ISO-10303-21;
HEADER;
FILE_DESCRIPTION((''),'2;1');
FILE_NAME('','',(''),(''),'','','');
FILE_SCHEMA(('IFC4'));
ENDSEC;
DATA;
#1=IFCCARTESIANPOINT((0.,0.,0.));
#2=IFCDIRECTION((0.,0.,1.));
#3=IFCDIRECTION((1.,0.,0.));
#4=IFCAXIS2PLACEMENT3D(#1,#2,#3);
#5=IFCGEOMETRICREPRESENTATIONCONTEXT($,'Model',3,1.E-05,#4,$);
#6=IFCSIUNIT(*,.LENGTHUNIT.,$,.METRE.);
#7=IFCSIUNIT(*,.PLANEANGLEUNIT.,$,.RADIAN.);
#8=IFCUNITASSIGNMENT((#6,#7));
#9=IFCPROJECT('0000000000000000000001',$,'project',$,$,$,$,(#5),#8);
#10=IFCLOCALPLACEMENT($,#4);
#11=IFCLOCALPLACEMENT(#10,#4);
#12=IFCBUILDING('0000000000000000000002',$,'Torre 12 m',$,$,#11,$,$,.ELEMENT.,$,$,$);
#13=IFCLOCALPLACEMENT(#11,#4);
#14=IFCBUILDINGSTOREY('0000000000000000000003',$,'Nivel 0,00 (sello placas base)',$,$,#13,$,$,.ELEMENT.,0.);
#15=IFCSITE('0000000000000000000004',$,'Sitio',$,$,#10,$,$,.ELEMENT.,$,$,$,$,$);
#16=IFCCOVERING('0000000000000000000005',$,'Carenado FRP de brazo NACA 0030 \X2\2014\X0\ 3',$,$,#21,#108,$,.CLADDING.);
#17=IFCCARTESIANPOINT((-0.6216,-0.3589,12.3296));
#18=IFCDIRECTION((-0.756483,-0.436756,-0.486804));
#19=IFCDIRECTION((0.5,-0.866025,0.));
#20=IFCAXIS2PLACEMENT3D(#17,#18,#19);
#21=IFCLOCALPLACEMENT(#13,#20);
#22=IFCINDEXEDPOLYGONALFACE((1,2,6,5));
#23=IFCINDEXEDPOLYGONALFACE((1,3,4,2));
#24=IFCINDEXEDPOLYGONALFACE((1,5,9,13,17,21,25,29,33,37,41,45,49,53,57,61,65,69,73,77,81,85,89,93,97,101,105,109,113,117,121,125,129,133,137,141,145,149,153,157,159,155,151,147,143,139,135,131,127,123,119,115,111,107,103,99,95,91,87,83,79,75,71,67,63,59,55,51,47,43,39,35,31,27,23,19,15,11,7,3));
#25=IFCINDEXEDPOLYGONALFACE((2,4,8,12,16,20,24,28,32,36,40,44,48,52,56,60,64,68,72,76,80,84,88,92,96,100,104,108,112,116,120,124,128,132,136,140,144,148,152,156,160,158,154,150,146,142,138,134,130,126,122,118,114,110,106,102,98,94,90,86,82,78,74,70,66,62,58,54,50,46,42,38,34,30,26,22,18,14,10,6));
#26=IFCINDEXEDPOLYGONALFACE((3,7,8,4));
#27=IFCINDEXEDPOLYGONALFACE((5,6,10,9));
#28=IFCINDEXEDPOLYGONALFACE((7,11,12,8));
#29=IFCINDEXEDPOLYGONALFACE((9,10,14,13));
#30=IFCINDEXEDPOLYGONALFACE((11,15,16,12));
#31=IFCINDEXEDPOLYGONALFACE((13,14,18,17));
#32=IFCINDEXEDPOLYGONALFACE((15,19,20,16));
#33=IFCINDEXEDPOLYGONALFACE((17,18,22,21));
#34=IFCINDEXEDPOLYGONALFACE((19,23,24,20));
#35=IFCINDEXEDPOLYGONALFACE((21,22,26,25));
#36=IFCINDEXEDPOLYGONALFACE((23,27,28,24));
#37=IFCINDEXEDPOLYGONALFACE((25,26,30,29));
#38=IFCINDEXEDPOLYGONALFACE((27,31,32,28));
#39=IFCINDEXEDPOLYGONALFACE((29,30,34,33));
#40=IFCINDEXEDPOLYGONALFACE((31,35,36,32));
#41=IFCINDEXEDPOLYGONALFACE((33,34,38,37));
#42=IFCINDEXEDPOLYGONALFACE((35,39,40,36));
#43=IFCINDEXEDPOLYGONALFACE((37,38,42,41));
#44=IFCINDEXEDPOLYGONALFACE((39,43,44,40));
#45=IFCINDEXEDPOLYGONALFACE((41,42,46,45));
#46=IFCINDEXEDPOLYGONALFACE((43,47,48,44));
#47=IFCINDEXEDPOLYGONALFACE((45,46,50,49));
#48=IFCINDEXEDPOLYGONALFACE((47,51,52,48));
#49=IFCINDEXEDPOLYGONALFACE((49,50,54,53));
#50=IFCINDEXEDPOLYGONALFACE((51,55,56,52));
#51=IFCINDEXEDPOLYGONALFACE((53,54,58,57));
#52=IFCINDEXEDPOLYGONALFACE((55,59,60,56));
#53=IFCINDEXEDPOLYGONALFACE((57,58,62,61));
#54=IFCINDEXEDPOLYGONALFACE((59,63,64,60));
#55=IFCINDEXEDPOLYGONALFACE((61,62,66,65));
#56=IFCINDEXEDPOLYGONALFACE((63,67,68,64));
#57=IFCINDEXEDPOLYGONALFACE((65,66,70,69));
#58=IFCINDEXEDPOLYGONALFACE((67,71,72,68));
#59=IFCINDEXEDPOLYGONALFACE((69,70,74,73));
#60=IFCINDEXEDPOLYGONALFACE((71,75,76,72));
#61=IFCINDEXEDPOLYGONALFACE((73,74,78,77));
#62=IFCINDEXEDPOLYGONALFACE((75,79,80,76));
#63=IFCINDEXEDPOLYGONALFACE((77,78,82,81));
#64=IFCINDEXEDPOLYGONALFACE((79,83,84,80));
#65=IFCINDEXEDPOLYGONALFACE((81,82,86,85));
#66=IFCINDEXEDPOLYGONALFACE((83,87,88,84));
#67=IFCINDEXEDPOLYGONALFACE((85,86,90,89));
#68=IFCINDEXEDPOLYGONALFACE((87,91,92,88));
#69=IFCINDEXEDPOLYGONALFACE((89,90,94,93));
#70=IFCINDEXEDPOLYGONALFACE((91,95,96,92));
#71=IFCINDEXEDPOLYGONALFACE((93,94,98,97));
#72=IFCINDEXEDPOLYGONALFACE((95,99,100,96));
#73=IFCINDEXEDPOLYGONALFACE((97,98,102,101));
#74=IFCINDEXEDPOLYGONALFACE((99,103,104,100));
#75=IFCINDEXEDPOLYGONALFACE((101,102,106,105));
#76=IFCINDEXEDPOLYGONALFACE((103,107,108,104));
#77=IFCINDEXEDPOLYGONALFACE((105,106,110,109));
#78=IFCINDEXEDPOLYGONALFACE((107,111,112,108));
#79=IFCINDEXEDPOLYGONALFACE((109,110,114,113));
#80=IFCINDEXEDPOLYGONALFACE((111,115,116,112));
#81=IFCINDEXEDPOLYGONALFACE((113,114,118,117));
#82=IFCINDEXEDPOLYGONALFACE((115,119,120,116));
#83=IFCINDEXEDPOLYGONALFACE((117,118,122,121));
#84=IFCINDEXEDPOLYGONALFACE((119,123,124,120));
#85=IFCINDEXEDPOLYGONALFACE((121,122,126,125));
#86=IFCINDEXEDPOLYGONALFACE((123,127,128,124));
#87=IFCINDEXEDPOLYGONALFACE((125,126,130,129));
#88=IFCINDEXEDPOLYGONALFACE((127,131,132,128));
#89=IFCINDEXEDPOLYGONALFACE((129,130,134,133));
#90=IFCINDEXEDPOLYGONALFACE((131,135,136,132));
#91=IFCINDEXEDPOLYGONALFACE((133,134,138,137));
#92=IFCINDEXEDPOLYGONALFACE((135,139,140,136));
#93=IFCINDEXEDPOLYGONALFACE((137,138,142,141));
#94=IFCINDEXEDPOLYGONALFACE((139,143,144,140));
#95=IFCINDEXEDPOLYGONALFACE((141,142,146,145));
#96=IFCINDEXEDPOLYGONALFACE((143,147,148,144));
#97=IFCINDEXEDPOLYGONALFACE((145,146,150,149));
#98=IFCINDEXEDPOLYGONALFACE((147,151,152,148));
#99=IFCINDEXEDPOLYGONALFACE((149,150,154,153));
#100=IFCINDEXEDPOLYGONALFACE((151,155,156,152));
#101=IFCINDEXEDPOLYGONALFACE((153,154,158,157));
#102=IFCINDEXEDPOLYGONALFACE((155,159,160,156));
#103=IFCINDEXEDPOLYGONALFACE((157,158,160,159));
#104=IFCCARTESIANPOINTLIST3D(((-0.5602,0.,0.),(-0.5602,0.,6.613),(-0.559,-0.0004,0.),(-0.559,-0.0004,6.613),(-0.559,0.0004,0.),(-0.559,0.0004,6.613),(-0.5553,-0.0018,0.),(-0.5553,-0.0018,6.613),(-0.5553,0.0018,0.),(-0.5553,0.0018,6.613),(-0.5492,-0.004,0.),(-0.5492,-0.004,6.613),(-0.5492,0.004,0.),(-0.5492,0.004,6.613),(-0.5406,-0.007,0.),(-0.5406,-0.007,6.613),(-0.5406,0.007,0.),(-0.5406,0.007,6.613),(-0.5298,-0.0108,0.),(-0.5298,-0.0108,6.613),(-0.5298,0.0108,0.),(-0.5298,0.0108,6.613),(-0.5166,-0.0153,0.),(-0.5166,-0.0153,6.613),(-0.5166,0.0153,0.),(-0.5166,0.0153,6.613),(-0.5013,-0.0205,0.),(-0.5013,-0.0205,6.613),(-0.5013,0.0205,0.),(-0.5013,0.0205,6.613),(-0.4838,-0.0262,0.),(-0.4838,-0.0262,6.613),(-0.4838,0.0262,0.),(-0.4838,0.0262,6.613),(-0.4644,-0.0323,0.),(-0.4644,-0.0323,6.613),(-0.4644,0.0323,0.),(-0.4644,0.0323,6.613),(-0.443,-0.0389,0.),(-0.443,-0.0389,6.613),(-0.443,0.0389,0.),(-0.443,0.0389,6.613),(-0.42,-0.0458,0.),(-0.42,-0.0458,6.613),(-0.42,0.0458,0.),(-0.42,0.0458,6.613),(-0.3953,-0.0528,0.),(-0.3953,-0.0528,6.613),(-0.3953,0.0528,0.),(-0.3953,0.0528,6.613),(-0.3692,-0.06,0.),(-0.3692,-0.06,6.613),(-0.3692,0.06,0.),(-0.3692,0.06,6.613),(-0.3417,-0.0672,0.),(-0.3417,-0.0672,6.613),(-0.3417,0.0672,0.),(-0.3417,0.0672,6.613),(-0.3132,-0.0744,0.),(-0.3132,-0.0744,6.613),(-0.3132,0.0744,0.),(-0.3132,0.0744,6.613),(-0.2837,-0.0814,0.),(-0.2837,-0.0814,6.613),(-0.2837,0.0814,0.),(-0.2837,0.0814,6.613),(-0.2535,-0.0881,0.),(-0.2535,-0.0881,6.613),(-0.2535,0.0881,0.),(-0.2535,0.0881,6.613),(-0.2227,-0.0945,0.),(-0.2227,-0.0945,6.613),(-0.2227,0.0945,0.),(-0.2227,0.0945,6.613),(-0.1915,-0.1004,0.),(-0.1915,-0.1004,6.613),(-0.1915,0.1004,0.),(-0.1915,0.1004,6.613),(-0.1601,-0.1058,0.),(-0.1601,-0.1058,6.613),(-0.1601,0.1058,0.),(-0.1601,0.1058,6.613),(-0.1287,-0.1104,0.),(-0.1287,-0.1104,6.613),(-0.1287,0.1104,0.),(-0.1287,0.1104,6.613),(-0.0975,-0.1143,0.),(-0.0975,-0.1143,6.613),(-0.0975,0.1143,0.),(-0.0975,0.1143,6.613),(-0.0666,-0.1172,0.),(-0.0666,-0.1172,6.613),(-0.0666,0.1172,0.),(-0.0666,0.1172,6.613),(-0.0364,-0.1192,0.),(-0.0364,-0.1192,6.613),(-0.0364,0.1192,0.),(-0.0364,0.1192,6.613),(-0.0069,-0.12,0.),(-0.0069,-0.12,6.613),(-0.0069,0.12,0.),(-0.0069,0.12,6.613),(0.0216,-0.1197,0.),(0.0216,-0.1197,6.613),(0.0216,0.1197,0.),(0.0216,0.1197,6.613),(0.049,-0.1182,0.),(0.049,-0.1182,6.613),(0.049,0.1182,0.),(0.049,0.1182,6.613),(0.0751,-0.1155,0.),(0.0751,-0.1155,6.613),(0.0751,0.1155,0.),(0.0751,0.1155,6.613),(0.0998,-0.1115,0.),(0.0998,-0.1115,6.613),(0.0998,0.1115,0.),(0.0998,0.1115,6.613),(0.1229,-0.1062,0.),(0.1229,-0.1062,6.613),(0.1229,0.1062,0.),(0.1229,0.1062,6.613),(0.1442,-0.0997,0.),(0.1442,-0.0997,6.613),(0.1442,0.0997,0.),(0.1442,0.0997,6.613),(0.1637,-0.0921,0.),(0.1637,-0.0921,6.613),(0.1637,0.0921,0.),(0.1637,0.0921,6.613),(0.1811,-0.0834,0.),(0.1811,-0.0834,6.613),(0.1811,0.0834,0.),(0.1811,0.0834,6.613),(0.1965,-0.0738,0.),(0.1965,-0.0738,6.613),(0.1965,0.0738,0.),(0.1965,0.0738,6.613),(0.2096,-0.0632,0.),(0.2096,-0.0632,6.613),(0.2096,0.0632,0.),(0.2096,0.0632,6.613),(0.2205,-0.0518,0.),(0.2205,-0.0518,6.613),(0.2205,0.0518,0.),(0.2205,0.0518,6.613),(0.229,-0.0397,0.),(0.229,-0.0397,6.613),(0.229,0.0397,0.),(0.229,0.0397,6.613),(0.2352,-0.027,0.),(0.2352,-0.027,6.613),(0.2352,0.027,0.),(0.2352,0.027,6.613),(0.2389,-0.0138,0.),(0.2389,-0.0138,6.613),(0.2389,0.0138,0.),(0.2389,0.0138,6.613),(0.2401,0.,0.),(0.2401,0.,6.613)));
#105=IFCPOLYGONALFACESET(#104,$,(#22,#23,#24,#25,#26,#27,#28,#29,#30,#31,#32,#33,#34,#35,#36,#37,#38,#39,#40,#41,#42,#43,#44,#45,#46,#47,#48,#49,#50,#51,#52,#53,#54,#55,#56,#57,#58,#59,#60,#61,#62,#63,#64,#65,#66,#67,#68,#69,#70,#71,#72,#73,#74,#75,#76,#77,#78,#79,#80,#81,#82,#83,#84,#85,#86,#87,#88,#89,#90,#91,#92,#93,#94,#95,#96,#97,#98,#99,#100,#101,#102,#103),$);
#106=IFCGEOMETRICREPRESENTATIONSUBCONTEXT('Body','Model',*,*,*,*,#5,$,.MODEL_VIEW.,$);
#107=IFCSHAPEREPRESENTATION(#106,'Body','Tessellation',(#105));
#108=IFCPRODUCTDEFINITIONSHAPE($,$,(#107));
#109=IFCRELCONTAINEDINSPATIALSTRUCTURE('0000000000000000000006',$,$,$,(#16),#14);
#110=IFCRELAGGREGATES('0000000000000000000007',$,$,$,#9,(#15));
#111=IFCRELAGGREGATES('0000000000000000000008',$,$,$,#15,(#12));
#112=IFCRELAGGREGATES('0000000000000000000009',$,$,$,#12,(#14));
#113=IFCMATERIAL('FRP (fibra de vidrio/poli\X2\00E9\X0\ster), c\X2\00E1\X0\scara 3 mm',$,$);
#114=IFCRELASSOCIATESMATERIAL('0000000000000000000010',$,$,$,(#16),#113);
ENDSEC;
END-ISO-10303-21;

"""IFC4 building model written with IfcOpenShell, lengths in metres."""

from ifc_helpers import new_model, si_unit, frame, origin, origin_with_axes, place, context, subcontext, project, spatial, polyline, outline, extrude, material, element, save


model = new_model("IFC4")

# Units and contexts
model_context = context("Model", 3, precision=1e-05, world=origin_with_axes())
body_context = subcontext(model_context, "Body", "Model", "MODEL_VIEW")
ifc_project = project(units=[si_unit("LENGTHUNIT", "METRE"), si_unit("PLANEANGLEUNIT", "RADIAN")], contexts=[model_context])

# Site, building, storey
site_placement = place(None, origin_with_axes())
site = spatial("IfcSite", under=ifc_project, at=site_placement, Name="Sitio", CompositionType="ELEMENT")
building_placement = place(site_placement, origin_with_axes())
building = spatial("IfcBuilding", under=site, at=building_placement, Name="Torre 12 m", CompositionType="ELEMENT")
storey_placement = place(building_placement, origin_with_axes())
storey = spatial("IfcBuildingStorey", under=building, at=storey_placement, Name="Nivel 0,00 (sello placas base)", CompositionType="ELEMENT", Elevation=0.0)

# Covering
ifc_material_1 = material(Name="FRP (fibra de vidrio/poliéster), cáscara 3 mm")
covering_1_placement = place(storey_placement, frame((-0.6216, -0.3589, 12.3296), z_axis=(-0.756483, -0.436756, -0.486804), x_axis=(0.5, -0.866025, 0.0)))
element("IfcCovering", 1, at=covering_1_placement, inside=storey, material=ifc_material_1, Name="Carenado FRP de brazo NACA 0030 — 3", PredefinedType="CLADDING", context=body_context, shape_type="SweptSolid", body=[
    extrude(outline(polyline([(0.2401, 0.0), (0.2389, 0.0138), (0.2352, 0.027), (0.229, 0.0397), (0.2205, 0.0518), (0.2096, 0.0632), (0.1965, 0.0738), (0.1811, 0.0834), (0.1637, 0.0921), (0.1442, 0.0997), (0.1229, 0.1062), (0.0998, 0.1115), (0.0751, 0.1155), (0.049, 0.1182), (0.0216, 0.1197), (-0.0069, 0.12), (-0.0364, 0.1192), (-0.0666, 0.1172), (-0.0975, 0.1143), (-0.1287, 0.1104), (-0.1601, 0.1058), (-0.1915, 0.1004), (-0.2227, 0.0945), (-0.2535, 0.0881), (-0.2837, 0.0814), (-0.3132, 0.0744), (-0.3417, 0.0672), (-0.3692, 0.06), (-0.3953, 0.0528), (-0.42, 0.0458), (-0.443, 0.0389), (-0.4644, 0.0323), (-0.4838, 0.0262), (-0.5013, 0.0205), (-0.5166, 0.0153), (-0.5298, 0.0108), (-0.5406, 0.007), (-0.5492, 0.004), (-0.5553, 0.0018), (-0.559, 0.0004), (-0.5602, 0.0), (-0.559, -0.0004), (-0.5553, -0.0018), (-0.5492, -0.004), (-0.5406, -0.007), (-0.5298, -0.0108), (-0.5166, -0.0153), (-0.5013, -0.0205), (-0.4838, -0.0262), (-0.4644, -0.0323), (-0.443, -0.0389), (-0.42, -0.0458), (-0.3953, -0.0528), (-0.3692, -0.06), (-0.3417, -0.0672), (-0.3132, -0.0744), (-0.2837, -0.0814), (-0.2535, -0.0881), (-0.2227, -0.0945), (-0.1915, -0.1004), (-0.1601, -0.1058), (-0.1287, -0.1104), (-0.0975, -0.1143), (-0.0666, -0.1172), (-0.0364, -0.1192), (-0.0069, -0.12), (0.0216, -0.1197), (0.049, -0.1182), (0.0751, -0.1155), (0.0998, -0.1115), (0.1229, -0.1062), (0.1442, -0.0997), (0.1637, -0.0921), (0.1811, -0.0834), (0.1965, -0.0738), (0.2096, -0.0632), (0.2205, -0.0518), (0.229, -0.0397), (0.2352, -0.027), (0.2389, -0.0138), (0.2401, 0.0)])), origin(), (0.0, 0.0, 1.0), 6.613),
])

save(model, "model.ifc")
